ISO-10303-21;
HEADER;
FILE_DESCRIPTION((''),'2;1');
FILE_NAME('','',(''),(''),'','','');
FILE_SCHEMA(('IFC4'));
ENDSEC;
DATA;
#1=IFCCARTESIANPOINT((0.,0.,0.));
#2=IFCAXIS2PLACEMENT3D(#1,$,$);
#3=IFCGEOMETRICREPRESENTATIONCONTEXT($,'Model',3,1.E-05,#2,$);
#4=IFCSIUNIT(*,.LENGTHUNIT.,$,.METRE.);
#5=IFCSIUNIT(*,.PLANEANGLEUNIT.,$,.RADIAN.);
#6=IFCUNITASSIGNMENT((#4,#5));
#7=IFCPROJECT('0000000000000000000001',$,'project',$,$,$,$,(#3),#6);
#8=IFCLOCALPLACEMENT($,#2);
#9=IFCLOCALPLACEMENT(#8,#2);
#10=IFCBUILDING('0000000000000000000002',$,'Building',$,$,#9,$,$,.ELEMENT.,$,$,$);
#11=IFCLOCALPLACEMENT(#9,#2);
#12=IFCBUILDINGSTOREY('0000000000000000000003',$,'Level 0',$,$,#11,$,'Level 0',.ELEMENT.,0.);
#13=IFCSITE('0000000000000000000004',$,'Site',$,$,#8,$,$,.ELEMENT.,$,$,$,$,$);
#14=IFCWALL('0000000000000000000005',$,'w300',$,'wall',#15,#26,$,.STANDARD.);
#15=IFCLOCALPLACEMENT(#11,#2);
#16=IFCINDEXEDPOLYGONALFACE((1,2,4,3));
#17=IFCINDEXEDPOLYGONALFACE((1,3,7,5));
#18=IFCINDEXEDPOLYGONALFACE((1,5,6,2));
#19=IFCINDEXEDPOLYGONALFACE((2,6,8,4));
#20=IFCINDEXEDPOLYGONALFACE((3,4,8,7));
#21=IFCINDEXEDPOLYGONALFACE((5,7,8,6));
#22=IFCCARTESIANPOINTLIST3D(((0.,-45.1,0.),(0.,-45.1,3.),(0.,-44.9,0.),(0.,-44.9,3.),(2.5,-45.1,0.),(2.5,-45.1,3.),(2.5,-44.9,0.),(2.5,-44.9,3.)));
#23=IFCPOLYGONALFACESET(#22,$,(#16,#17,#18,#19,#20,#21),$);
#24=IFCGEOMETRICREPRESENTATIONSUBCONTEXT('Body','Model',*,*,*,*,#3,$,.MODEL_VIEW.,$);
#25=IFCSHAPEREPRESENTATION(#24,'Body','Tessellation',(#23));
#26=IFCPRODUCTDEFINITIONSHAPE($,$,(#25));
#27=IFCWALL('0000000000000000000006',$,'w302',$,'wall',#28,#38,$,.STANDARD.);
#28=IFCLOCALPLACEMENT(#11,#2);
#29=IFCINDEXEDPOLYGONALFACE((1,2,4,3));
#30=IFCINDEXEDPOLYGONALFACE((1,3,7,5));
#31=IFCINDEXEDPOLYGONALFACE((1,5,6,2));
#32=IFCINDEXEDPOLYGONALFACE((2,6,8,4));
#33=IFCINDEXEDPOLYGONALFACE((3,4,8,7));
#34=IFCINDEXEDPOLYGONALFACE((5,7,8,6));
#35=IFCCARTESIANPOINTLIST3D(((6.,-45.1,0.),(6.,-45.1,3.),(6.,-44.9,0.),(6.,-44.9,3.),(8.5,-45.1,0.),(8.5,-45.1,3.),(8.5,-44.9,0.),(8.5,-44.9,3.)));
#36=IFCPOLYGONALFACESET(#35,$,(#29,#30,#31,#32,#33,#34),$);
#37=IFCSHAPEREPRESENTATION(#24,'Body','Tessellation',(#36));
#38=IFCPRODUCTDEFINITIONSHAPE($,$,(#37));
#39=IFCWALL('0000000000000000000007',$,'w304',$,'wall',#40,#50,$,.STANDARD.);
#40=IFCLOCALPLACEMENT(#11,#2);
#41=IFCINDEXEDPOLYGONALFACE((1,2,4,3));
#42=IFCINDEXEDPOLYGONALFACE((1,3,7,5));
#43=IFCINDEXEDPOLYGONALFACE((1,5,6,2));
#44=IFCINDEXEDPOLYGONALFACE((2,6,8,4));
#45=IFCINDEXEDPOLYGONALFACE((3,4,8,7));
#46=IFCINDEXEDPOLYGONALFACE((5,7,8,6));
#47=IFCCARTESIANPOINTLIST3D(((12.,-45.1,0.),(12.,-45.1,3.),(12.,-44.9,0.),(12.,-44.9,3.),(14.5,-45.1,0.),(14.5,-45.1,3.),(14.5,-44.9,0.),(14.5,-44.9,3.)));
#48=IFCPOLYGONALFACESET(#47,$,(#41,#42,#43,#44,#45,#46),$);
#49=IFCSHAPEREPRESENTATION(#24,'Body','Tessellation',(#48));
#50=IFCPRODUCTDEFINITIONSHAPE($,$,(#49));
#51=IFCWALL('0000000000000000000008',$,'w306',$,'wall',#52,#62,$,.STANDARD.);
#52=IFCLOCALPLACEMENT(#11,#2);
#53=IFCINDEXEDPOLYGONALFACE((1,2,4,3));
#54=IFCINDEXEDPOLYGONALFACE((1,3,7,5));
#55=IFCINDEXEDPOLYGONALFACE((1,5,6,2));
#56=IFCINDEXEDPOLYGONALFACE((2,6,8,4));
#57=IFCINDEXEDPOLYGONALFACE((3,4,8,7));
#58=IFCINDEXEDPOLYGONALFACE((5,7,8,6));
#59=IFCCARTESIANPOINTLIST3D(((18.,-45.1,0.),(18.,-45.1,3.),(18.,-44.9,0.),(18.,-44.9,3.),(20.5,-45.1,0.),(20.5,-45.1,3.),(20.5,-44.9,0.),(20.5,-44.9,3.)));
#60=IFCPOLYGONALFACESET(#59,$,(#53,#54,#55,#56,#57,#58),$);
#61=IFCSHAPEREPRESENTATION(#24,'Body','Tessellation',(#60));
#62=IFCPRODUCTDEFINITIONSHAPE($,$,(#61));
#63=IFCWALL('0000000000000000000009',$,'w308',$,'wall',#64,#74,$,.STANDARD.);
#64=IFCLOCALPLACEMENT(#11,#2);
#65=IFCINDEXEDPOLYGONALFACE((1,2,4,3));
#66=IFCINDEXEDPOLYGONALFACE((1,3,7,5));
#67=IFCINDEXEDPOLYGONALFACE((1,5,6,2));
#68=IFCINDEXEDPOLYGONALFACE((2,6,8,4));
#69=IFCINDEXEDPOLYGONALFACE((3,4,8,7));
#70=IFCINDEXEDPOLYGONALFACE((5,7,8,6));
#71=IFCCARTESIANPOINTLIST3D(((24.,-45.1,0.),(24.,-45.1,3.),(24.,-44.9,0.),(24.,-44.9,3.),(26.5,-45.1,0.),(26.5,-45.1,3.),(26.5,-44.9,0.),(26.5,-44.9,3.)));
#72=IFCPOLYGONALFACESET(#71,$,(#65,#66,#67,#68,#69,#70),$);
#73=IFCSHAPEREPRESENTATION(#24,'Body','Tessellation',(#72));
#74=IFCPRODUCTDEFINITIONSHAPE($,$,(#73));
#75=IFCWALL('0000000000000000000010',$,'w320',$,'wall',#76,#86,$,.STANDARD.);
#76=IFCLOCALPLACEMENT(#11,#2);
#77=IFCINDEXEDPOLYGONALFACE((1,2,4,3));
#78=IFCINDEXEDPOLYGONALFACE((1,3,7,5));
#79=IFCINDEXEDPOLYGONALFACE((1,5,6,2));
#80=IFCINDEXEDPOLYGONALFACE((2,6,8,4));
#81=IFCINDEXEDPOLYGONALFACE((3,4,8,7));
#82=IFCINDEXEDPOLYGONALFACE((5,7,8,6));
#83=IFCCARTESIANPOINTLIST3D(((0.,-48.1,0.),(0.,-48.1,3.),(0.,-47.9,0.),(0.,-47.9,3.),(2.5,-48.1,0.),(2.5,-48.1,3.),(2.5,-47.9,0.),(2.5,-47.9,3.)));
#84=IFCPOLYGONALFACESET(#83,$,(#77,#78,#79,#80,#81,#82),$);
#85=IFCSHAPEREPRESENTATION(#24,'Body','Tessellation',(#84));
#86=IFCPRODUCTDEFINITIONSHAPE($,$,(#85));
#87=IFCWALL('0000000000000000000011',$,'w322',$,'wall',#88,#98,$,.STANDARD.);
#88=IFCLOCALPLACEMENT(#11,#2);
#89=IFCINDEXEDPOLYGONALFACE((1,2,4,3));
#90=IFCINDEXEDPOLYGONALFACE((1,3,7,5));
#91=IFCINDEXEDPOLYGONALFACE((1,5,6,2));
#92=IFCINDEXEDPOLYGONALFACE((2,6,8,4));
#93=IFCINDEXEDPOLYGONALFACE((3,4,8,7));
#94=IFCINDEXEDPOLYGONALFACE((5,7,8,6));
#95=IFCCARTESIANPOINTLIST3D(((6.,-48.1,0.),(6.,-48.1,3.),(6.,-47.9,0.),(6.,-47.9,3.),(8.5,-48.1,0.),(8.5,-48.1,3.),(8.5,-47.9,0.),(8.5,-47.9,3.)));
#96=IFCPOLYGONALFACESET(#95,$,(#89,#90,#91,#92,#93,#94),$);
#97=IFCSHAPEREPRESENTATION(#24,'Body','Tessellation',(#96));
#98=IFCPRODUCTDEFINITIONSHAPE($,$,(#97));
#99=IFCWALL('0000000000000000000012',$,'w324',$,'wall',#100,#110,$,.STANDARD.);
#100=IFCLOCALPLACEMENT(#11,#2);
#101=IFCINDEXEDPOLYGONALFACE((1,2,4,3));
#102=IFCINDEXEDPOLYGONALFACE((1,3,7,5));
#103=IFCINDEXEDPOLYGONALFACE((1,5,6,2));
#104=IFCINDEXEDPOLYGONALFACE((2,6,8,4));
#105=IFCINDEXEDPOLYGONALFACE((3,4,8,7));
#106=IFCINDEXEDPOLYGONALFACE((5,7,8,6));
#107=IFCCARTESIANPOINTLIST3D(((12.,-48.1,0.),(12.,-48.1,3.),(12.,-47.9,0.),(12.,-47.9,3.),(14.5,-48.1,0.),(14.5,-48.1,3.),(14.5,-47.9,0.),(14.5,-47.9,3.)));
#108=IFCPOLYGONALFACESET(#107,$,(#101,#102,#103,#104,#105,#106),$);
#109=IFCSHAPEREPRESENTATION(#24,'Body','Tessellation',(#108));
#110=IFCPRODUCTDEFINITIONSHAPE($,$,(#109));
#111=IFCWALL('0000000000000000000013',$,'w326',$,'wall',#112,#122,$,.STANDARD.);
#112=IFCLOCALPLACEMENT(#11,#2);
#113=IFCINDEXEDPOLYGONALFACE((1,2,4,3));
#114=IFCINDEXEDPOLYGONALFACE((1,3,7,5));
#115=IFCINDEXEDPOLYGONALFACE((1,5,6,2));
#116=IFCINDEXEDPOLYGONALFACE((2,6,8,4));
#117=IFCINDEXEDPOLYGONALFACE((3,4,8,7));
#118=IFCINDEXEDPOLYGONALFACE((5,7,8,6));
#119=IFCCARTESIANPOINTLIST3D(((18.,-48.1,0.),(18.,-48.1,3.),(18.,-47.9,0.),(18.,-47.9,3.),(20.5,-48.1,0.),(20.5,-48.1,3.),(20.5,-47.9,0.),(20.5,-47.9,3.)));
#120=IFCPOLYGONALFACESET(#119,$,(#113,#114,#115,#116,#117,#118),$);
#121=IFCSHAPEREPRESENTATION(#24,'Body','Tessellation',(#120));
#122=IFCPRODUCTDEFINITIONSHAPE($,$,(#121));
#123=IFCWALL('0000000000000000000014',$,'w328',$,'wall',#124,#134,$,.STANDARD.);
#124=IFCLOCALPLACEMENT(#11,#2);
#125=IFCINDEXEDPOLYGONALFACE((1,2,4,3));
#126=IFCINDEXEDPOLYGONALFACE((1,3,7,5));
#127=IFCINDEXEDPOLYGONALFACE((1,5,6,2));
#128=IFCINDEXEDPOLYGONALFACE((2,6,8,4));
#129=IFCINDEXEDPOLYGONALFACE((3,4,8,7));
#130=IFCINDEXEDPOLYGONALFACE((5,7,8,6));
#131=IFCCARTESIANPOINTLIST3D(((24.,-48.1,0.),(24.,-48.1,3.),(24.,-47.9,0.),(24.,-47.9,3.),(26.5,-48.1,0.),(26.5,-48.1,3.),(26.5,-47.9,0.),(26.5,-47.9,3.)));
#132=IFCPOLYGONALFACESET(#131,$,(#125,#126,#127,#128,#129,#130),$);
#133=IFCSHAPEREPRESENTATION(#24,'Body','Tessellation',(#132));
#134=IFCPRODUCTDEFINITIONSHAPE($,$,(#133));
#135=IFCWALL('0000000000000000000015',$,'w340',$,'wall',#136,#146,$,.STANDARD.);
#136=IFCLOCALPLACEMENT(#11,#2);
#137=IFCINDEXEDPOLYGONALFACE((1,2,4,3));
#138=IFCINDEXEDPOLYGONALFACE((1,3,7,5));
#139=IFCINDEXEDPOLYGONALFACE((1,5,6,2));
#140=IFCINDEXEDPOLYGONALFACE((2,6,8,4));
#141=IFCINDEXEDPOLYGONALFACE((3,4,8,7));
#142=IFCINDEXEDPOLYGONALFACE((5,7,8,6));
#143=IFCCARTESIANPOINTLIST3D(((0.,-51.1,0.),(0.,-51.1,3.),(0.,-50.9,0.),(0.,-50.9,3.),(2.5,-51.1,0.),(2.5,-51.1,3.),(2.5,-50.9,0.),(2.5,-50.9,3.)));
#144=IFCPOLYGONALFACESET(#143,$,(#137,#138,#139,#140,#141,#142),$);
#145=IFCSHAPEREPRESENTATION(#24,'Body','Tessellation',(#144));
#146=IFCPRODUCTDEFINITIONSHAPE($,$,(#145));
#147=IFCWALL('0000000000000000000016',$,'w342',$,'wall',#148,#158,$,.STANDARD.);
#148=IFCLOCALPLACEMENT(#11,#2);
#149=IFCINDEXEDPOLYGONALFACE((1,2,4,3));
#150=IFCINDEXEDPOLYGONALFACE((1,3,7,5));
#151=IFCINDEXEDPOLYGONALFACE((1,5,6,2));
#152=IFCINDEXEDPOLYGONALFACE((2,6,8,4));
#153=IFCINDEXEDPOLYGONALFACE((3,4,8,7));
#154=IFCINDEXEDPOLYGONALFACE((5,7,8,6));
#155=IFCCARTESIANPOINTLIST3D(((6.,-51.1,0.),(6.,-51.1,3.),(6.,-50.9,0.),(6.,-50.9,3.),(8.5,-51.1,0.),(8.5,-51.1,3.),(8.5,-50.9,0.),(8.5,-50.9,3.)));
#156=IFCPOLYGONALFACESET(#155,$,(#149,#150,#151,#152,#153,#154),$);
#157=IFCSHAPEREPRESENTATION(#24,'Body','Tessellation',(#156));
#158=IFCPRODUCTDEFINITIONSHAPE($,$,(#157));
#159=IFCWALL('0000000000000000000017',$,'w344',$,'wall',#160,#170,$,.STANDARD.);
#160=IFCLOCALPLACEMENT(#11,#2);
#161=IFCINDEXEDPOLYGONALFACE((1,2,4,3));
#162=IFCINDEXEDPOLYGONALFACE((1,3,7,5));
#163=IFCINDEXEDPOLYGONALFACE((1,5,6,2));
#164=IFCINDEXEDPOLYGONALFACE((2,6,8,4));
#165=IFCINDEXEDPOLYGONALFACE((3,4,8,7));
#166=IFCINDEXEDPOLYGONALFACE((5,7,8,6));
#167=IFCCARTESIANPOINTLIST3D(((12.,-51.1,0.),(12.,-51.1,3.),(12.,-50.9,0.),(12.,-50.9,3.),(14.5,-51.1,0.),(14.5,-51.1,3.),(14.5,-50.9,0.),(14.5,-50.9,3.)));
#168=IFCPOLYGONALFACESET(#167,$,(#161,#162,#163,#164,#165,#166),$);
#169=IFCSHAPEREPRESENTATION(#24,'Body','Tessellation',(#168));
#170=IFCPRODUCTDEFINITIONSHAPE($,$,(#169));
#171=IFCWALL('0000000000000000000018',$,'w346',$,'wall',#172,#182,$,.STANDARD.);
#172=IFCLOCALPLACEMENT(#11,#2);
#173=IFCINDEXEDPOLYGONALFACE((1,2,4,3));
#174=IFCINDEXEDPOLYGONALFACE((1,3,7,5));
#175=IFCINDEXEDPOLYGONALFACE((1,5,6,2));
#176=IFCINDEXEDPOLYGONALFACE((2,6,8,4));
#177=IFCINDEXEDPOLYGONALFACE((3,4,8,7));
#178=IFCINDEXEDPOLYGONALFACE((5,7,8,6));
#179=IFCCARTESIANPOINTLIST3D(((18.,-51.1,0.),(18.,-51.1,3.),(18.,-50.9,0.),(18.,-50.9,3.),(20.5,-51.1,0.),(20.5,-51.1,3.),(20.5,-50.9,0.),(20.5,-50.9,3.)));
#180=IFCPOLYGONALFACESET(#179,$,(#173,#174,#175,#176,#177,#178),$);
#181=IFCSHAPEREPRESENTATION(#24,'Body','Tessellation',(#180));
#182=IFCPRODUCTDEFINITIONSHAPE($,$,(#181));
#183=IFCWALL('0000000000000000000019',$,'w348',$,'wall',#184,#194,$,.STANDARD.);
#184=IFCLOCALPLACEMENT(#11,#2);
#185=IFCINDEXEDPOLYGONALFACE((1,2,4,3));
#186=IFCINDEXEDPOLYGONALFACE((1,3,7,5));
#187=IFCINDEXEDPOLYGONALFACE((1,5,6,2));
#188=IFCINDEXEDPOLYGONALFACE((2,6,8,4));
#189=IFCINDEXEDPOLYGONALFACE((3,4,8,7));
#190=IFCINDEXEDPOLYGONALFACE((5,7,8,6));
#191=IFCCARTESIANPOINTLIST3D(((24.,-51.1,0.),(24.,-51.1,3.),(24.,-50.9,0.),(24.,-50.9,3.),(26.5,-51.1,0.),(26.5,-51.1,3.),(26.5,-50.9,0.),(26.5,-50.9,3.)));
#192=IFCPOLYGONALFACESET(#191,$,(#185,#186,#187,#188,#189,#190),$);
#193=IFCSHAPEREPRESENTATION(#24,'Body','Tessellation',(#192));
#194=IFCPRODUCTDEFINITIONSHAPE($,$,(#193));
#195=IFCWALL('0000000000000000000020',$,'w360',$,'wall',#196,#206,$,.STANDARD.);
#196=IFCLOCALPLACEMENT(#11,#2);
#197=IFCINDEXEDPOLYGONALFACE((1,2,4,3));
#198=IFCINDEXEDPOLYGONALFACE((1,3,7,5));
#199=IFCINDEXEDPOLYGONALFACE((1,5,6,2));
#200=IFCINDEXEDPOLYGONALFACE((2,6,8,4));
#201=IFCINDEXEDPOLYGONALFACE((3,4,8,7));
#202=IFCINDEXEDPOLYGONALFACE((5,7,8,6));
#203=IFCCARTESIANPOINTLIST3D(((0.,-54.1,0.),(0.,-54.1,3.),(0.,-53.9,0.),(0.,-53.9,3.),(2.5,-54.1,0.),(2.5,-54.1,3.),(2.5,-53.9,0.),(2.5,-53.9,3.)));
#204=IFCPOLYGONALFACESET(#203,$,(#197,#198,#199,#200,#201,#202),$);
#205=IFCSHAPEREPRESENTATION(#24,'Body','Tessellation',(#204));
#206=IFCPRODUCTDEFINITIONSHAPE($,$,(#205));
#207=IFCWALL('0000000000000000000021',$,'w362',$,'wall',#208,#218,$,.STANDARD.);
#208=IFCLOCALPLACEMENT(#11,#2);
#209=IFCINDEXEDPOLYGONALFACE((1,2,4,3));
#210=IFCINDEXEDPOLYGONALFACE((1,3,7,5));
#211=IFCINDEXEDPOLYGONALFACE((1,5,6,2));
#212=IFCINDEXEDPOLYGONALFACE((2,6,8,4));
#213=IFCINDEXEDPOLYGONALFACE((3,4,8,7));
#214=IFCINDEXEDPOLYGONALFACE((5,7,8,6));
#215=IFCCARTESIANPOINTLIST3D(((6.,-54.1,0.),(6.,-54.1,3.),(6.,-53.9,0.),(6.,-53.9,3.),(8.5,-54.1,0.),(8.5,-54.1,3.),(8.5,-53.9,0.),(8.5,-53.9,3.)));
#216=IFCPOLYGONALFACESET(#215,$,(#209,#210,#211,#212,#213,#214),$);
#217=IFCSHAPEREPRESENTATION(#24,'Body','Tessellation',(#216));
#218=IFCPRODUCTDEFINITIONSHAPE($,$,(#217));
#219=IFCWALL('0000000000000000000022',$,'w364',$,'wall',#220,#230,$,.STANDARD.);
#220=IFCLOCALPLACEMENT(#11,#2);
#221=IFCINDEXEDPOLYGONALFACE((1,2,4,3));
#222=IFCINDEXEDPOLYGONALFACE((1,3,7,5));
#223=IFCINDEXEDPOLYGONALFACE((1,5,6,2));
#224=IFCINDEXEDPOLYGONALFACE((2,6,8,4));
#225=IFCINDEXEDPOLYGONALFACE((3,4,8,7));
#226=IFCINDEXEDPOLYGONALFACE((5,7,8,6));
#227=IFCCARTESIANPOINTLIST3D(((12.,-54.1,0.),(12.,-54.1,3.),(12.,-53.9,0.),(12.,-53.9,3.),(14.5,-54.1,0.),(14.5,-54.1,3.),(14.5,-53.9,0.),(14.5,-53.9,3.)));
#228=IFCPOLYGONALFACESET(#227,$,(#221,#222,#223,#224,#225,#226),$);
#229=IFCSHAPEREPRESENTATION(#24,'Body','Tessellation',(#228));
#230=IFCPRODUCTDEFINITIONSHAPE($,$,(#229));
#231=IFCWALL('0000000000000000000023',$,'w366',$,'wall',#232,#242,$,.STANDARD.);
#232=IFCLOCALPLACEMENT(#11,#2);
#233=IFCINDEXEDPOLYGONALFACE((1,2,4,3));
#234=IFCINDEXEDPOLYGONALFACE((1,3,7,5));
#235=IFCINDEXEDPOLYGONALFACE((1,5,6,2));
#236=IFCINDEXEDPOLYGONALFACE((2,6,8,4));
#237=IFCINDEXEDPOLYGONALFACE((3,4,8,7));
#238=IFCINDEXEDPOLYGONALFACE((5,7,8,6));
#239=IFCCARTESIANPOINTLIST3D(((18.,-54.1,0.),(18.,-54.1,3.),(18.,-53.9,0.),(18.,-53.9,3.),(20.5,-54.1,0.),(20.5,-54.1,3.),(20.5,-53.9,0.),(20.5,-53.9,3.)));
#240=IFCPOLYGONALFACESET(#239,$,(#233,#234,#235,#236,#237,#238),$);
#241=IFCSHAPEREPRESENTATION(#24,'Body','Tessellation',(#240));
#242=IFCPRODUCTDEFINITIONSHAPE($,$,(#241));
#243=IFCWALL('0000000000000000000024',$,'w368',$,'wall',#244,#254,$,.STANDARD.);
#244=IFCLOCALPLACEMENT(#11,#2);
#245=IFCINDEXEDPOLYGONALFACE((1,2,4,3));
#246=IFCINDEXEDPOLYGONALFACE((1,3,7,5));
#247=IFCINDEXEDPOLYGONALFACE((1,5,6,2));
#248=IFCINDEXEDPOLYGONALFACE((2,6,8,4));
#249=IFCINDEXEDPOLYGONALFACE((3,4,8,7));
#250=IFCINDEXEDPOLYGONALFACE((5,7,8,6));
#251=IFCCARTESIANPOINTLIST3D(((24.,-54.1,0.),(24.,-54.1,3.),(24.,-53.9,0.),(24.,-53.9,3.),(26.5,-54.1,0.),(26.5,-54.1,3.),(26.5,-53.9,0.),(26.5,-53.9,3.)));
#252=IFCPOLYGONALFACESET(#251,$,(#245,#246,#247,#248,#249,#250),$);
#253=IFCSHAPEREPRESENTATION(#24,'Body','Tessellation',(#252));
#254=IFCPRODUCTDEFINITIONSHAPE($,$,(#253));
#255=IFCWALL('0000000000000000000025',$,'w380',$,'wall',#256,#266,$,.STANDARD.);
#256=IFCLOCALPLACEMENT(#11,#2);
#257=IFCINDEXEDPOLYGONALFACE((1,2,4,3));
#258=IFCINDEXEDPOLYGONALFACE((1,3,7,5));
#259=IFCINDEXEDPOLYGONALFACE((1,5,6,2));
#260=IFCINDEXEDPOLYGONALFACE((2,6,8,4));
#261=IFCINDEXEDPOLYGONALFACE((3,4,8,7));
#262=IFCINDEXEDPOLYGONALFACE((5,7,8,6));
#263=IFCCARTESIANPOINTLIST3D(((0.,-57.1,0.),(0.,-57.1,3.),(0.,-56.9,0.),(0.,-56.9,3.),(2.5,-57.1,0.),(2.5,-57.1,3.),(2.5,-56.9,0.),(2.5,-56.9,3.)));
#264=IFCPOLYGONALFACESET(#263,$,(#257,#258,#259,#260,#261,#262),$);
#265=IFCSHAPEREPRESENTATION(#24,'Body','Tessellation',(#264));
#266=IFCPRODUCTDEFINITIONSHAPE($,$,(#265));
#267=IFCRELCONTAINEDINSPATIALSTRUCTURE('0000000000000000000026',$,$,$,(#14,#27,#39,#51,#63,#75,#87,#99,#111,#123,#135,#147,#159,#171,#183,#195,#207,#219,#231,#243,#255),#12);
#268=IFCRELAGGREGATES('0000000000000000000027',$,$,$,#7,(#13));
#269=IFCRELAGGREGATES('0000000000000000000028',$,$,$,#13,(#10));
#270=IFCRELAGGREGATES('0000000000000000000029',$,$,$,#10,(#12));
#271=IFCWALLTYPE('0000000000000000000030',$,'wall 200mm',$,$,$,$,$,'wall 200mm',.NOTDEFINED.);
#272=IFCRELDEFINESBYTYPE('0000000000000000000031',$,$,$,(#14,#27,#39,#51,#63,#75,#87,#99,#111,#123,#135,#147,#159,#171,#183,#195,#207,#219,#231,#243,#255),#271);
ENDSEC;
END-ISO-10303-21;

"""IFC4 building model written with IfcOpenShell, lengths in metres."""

from ifc_helpers import new_model, si_unit, frame, frame_2d, origin, place, context, subcontext, project, spatial, rectangle, extrude, type_object, element, save


model = new_model("IFC4")

# Units and contexts
model_context = context("Model", 3, precision=1e-05, world=origin())
body_context = subcontext(model_context, "Body", "Model", "MODEL_VIEW")
ifc_project = project(units=[si_unit("LENGTHUNIT", "METRE"), si_unit("PLANEANGLEUNIT", "RADIAN")], contexts=[model_context])

# Site, building, storey
site_placement = place(None, origin())
site = spatial("IfcSite", under=ifc_project, at=site_placement, Name="Site", CompositionType="ELEMENT")
building_placement = place(site_placement, origin())
building = spatial("IfcBuilding", under=site, at=building_placement, Name="Building", CompositionType="ELEMENT")
storey_placement = place(building_placement, origin())
storey = spatial("IfcBuildingStorey", under=building, at=storey_placement, Name="Level 0", LongName="Level 0", CompositionType="ELEMENT", Elevation=0.0)

# Walls
wall_type = type_object("IfcWallType", Name="wall 200mm", ElementType="wall 200mm", PredefinedType="NOTDEFINED")
for number, where, z_axis, x_axis, name in (
    (1, (0.0, -45.0, 0.0), (0.0, 0.0, 1.0), (1.0, 0.0, 0.0), "w300"),
    (2, (6.0, -45.0, 0.0), (0.0, 0.0, 1.0), (1.0, 0.0, 0.0), "w302"),
    (3, (12.0, -45.0, 0.0), (0.0, 0.0, 1.0), (1.0, 0.0, 0.0), "w304"),
    (4, (18.0, -45.0, 0.0), (0.0, 0.0, 1.0), (1.0, 0.0, 0.0), "w306"),
    (5, (24.0, -45.0, 0.0), (0.0, 0.0, 1.0), (1.0, 0.0, 0.0), "w308"),
    (6, (0.0, -48.0, 0.0), (0.0, 0.0, 1.0), (1.0, 0.0, 0.0), "w320"),
    (7, (6.0, -48.0, 0.0), (0.0, 0.0, 1.0), (1.0, 0.0, 0.0), "w322"),
    (8, (12.0, -48.0, 0.0), (0.0, 0.0, 1.0), (1.0, 0.0, 0.0), "w324"),
    (9, (18.0, -48.0, 0.0), (0.0, 0.0, 1.0), (1.0, 0.0, 0.0), "w326"),
    (10, (24.0, -48.0, 0.0), (0.0, 0.0, 1.0), (1.0, 0.0, 0.0), "w328"),
    (11, (0.0, -51.0, 0.0), (0.0, 0.0, 1.0), (1.0, 0.0, 0.0), "w340"),
    (12, (6.0, -51.0, 0.0), (0.0, 0.0, 1.0), (1.0, 0.0, 0.0), "w342"),
    (13, (12.0, -51.0, 0.0), (0.0, 0.0, 1.0), (1.0, 0.0, 0.0), "w344"),
    (14, (18.0, -51.0, 0.0), (0.0, 0.0, 1.0), (1.0, 0.0, 0.0), "w346"),
    (15, (24.0, -51.0, 0.0), (0.0, 0.0, 1.0), (1.0, 0.0, 0.0), "w348"),
    (16, (0.0, -54.0, 0.0), (0.0, 0.0, 1.0), (1.0, 0.0, 0.0), "w360"),
    (17, (6.0, -54.0, 0.0), (0.0, 0.0, 1.0), (1.0, 0.0, 0.0), "w362"),
    (18, (12.0, -54.0, 0.0), (0.0, 0.0, 1.0), (1.0, 0.0, 0.0), "w364"),
    (19, (18.0, -54.0, 0.0), (0.0, 0.0, 1.0), (1.0, 0.0, 0.0), "w366"),
    (20, (24.0, -54.0, 0.0), (0.0, 0.0, 1.0), (1.0, 0.0, 0.0), "w368"),
    (21, (0.0, -57.0, 0.0), (0.0, 0.0, 1.0), (1.0, 0.0, 0.0), "w380"),
):
    element("IfcWall", number, at=place(storey_placement, frame(where, z_axis=z_axis, x_axis=x_axis)), inside=storey, type_object=wall_type, Name=name, ObjectType="wall", PredefinedType="STANDARD", context=body_context, shape_type="SweptSolid", body=[
        extrude(rectangle(XDim=2.5, YDim=0.2, at=frame_2d((1.25, 0.0))), origin(), (0.0, 0.0, 1.0), 3.0),
    ])

save(model, "model.ifc")
